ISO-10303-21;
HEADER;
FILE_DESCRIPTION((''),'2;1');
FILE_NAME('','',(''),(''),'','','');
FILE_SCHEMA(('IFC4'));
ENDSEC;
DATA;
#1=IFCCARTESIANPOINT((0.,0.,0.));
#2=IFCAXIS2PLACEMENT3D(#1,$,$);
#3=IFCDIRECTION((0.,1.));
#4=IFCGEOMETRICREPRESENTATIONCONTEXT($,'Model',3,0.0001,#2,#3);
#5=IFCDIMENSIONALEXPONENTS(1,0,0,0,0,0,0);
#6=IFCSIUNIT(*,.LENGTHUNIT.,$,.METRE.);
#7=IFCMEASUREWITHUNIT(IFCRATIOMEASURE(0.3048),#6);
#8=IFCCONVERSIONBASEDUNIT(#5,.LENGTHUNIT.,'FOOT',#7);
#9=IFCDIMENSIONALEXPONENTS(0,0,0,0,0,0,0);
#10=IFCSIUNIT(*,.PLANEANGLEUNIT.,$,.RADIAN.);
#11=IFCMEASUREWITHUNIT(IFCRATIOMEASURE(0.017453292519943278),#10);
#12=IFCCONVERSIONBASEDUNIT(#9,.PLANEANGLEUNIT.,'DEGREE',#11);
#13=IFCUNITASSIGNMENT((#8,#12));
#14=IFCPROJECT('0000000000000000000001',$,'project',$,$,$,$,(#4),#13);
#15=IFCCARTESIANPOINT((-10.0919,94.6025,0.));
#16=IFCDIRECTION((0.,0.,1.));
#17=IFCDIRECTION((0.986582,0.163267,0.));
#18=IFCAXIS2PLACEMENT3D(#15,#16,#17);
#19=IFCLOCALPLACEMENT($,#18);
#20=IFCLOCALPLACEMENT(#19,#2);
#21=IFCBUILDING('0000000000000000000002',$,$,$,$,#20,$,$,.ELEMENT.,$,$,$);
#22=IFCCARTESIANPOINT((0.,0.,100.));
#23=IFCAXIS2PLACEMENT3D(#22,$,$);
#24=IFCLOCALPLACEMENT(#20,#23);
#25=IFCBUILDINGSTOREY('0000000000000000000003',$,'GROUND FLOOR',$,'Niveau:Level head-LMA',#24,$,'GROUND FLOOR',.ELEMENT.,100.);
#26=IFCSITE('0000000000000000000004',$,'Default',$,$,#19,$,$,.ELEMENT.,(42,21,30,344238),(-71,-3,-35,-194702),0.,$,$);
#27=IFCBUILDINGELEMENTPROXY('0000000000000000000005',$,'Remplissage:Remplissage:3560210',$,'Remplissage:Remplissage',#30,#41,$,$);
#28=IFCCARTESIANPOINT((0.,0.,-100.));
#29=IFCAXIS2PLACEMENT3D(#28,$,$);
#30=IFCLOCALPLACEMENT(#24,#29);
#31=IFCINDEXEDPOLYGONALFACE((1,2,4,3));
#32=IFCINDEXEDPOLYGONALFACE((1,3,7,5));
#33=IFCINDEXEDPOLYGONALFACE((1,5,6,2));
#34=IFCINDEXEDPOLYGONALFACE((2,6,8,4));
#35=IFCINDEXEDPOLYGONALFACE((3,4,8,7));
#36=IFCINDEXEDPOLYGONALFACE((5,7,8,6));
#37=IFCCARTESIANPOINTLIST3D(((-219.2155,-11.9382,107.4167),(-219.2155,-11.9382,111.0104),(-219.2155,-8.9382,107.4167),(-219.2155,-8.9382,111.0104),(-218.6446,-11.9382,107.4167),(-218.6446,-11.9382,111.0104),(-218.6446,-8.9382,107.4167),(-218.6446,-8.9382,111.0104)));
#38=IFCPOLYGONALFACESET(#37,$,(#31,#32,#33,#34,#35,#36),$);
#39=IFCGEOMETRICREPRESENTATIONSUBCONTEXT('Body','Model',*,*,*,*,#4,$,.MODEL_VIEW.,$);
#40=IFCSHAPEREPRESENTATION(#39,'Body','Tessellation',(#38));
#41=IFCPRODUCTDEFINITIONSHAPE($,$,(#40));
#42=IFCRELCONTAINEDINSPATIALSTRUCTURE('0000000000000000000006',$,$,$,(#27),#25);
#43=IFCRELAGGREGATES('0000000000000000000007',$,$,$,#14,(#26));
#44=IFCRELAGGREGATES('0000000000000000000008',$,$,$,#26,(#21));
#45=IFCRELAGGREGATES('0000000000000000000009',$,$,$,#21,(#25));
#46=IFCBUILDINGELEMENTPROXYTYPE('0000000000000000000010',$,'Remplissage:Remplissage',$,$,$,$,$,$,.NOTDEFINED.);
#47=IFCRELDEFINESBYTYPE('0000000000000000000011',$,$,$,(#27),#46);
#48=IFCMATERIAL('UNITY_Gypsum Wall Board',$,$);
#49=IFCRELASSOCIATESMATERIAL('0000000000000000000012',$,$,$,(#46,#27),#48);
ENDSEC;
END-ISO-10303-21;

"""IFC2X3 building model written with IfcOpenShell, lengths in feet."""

from ifc_helpers import new_model, entity, si_unit, converted_unit, direction, frame, origin, origin_2d_with_axis, place, context, subcontext, project, spatial, rectangle, extrude, source, transform, mapped, material, type_object, type_shapes, element, save


model = new_model("IFC2X3")

# Units and contexts
model_context = context("Model", 3, precision=0.0001, world=origin(), true_north=direction((0.0, 1.0)))
body_context = subcontext(model_context, "Body", "Model", "MODEL_VIEW")
ifc_project = project(units=[converted_unit("LENGTHUNIT", "FOOT", entity("IfcRatioMeasure", 0.3048), si_unit("LENGTHUNIT", "METRE"), dimensions=[1, 0, 0, 0, 0, 0, 0]), converted_unit("PLANEANGLEUNIT", "DEGREE", entity("IfcRatioMeasure", 0.017453292519943278), si_unit("PLANEANGLEUNIT", "RADIAN"), dimensions=[0, 0, 0, 0, 0, 0, 0])], contexts=[model_context])

# Site, building, storey
site_placement = place(None, frame((-10.0919, 94.6025, 0.0), z_axis=(0.0, 0.0, 1.0), x_axis=(0.986582, 0.163267, 0.0)))
site = spatial("IfcSite", under=ifc_project, at=site_placement, Name="Default", CompositionType="ELEMENT", RefLatitude=(42, 21, 30, 344238), RefLongitude=(-71, -3, -35, -194702), RefElevation=0.0)
building_placement = place(site_placement, origin())
building = spatial("IfcBuilding", under=site, at=building_placement, CompositionType="ELEMENT")
storey_placement = place(building_placement, frame((0.0, 0.0, 100.0)))
storey = spatial("IfcBuildingStorey", under=building, at=storey_placement, Name="GROUND FLOOR", ObjectType="Niveau:Level head-LMA", LongName="GROUND FLOOR", CompositionType="ELEMENT", Elevation=100.0)

# Shared definitions
ifc_material_1 = material(Name="UNITY_Gypsum Wall Board")

# Building element proxy
building_element_proxy_type_1 = type_object("IfcBuildingElementProxyType", Name="Remplissage:Remplissage", PredefinedType="NOTDEFINED", material=ifc_material_1)
shared_shape_1 = source(origin(), body_context, "Body", "SweptSolid", [
    extrude(rectangle(XDim=0.5709, YDim=3.0, at=origin_2d_with_axis()), frame((-218.9301, -10.4382, 107.4167), z_axis=(0.0, 0.0, 1.0), x_axis=(-1.0, 0.0, 0.0)), (0.0, 0.0, 1.0), 3.5937),
])
type_shapes(building_element_proxy_type_1, [shared_shape_1])
proxy_1_placement = place(storey_placement, frame((0.0, 0.0, -100.0)))
element("IfcBuildingElementProxy", 1, at=proxy_1_placement, inside=storey, type_object=building_element_proxy_type_1, material=ifc_material_1, Name="Remplissage:Remplissage:3560210", ObjectType="Remplissage:Remplissage", context=body_context, shape_type="MappedRepresentation", body=[
    mapped(shared_shape_1, transform((0.0, 0.0, 0.0), scale=1.0)),
])

save(model, "model.ifc")
